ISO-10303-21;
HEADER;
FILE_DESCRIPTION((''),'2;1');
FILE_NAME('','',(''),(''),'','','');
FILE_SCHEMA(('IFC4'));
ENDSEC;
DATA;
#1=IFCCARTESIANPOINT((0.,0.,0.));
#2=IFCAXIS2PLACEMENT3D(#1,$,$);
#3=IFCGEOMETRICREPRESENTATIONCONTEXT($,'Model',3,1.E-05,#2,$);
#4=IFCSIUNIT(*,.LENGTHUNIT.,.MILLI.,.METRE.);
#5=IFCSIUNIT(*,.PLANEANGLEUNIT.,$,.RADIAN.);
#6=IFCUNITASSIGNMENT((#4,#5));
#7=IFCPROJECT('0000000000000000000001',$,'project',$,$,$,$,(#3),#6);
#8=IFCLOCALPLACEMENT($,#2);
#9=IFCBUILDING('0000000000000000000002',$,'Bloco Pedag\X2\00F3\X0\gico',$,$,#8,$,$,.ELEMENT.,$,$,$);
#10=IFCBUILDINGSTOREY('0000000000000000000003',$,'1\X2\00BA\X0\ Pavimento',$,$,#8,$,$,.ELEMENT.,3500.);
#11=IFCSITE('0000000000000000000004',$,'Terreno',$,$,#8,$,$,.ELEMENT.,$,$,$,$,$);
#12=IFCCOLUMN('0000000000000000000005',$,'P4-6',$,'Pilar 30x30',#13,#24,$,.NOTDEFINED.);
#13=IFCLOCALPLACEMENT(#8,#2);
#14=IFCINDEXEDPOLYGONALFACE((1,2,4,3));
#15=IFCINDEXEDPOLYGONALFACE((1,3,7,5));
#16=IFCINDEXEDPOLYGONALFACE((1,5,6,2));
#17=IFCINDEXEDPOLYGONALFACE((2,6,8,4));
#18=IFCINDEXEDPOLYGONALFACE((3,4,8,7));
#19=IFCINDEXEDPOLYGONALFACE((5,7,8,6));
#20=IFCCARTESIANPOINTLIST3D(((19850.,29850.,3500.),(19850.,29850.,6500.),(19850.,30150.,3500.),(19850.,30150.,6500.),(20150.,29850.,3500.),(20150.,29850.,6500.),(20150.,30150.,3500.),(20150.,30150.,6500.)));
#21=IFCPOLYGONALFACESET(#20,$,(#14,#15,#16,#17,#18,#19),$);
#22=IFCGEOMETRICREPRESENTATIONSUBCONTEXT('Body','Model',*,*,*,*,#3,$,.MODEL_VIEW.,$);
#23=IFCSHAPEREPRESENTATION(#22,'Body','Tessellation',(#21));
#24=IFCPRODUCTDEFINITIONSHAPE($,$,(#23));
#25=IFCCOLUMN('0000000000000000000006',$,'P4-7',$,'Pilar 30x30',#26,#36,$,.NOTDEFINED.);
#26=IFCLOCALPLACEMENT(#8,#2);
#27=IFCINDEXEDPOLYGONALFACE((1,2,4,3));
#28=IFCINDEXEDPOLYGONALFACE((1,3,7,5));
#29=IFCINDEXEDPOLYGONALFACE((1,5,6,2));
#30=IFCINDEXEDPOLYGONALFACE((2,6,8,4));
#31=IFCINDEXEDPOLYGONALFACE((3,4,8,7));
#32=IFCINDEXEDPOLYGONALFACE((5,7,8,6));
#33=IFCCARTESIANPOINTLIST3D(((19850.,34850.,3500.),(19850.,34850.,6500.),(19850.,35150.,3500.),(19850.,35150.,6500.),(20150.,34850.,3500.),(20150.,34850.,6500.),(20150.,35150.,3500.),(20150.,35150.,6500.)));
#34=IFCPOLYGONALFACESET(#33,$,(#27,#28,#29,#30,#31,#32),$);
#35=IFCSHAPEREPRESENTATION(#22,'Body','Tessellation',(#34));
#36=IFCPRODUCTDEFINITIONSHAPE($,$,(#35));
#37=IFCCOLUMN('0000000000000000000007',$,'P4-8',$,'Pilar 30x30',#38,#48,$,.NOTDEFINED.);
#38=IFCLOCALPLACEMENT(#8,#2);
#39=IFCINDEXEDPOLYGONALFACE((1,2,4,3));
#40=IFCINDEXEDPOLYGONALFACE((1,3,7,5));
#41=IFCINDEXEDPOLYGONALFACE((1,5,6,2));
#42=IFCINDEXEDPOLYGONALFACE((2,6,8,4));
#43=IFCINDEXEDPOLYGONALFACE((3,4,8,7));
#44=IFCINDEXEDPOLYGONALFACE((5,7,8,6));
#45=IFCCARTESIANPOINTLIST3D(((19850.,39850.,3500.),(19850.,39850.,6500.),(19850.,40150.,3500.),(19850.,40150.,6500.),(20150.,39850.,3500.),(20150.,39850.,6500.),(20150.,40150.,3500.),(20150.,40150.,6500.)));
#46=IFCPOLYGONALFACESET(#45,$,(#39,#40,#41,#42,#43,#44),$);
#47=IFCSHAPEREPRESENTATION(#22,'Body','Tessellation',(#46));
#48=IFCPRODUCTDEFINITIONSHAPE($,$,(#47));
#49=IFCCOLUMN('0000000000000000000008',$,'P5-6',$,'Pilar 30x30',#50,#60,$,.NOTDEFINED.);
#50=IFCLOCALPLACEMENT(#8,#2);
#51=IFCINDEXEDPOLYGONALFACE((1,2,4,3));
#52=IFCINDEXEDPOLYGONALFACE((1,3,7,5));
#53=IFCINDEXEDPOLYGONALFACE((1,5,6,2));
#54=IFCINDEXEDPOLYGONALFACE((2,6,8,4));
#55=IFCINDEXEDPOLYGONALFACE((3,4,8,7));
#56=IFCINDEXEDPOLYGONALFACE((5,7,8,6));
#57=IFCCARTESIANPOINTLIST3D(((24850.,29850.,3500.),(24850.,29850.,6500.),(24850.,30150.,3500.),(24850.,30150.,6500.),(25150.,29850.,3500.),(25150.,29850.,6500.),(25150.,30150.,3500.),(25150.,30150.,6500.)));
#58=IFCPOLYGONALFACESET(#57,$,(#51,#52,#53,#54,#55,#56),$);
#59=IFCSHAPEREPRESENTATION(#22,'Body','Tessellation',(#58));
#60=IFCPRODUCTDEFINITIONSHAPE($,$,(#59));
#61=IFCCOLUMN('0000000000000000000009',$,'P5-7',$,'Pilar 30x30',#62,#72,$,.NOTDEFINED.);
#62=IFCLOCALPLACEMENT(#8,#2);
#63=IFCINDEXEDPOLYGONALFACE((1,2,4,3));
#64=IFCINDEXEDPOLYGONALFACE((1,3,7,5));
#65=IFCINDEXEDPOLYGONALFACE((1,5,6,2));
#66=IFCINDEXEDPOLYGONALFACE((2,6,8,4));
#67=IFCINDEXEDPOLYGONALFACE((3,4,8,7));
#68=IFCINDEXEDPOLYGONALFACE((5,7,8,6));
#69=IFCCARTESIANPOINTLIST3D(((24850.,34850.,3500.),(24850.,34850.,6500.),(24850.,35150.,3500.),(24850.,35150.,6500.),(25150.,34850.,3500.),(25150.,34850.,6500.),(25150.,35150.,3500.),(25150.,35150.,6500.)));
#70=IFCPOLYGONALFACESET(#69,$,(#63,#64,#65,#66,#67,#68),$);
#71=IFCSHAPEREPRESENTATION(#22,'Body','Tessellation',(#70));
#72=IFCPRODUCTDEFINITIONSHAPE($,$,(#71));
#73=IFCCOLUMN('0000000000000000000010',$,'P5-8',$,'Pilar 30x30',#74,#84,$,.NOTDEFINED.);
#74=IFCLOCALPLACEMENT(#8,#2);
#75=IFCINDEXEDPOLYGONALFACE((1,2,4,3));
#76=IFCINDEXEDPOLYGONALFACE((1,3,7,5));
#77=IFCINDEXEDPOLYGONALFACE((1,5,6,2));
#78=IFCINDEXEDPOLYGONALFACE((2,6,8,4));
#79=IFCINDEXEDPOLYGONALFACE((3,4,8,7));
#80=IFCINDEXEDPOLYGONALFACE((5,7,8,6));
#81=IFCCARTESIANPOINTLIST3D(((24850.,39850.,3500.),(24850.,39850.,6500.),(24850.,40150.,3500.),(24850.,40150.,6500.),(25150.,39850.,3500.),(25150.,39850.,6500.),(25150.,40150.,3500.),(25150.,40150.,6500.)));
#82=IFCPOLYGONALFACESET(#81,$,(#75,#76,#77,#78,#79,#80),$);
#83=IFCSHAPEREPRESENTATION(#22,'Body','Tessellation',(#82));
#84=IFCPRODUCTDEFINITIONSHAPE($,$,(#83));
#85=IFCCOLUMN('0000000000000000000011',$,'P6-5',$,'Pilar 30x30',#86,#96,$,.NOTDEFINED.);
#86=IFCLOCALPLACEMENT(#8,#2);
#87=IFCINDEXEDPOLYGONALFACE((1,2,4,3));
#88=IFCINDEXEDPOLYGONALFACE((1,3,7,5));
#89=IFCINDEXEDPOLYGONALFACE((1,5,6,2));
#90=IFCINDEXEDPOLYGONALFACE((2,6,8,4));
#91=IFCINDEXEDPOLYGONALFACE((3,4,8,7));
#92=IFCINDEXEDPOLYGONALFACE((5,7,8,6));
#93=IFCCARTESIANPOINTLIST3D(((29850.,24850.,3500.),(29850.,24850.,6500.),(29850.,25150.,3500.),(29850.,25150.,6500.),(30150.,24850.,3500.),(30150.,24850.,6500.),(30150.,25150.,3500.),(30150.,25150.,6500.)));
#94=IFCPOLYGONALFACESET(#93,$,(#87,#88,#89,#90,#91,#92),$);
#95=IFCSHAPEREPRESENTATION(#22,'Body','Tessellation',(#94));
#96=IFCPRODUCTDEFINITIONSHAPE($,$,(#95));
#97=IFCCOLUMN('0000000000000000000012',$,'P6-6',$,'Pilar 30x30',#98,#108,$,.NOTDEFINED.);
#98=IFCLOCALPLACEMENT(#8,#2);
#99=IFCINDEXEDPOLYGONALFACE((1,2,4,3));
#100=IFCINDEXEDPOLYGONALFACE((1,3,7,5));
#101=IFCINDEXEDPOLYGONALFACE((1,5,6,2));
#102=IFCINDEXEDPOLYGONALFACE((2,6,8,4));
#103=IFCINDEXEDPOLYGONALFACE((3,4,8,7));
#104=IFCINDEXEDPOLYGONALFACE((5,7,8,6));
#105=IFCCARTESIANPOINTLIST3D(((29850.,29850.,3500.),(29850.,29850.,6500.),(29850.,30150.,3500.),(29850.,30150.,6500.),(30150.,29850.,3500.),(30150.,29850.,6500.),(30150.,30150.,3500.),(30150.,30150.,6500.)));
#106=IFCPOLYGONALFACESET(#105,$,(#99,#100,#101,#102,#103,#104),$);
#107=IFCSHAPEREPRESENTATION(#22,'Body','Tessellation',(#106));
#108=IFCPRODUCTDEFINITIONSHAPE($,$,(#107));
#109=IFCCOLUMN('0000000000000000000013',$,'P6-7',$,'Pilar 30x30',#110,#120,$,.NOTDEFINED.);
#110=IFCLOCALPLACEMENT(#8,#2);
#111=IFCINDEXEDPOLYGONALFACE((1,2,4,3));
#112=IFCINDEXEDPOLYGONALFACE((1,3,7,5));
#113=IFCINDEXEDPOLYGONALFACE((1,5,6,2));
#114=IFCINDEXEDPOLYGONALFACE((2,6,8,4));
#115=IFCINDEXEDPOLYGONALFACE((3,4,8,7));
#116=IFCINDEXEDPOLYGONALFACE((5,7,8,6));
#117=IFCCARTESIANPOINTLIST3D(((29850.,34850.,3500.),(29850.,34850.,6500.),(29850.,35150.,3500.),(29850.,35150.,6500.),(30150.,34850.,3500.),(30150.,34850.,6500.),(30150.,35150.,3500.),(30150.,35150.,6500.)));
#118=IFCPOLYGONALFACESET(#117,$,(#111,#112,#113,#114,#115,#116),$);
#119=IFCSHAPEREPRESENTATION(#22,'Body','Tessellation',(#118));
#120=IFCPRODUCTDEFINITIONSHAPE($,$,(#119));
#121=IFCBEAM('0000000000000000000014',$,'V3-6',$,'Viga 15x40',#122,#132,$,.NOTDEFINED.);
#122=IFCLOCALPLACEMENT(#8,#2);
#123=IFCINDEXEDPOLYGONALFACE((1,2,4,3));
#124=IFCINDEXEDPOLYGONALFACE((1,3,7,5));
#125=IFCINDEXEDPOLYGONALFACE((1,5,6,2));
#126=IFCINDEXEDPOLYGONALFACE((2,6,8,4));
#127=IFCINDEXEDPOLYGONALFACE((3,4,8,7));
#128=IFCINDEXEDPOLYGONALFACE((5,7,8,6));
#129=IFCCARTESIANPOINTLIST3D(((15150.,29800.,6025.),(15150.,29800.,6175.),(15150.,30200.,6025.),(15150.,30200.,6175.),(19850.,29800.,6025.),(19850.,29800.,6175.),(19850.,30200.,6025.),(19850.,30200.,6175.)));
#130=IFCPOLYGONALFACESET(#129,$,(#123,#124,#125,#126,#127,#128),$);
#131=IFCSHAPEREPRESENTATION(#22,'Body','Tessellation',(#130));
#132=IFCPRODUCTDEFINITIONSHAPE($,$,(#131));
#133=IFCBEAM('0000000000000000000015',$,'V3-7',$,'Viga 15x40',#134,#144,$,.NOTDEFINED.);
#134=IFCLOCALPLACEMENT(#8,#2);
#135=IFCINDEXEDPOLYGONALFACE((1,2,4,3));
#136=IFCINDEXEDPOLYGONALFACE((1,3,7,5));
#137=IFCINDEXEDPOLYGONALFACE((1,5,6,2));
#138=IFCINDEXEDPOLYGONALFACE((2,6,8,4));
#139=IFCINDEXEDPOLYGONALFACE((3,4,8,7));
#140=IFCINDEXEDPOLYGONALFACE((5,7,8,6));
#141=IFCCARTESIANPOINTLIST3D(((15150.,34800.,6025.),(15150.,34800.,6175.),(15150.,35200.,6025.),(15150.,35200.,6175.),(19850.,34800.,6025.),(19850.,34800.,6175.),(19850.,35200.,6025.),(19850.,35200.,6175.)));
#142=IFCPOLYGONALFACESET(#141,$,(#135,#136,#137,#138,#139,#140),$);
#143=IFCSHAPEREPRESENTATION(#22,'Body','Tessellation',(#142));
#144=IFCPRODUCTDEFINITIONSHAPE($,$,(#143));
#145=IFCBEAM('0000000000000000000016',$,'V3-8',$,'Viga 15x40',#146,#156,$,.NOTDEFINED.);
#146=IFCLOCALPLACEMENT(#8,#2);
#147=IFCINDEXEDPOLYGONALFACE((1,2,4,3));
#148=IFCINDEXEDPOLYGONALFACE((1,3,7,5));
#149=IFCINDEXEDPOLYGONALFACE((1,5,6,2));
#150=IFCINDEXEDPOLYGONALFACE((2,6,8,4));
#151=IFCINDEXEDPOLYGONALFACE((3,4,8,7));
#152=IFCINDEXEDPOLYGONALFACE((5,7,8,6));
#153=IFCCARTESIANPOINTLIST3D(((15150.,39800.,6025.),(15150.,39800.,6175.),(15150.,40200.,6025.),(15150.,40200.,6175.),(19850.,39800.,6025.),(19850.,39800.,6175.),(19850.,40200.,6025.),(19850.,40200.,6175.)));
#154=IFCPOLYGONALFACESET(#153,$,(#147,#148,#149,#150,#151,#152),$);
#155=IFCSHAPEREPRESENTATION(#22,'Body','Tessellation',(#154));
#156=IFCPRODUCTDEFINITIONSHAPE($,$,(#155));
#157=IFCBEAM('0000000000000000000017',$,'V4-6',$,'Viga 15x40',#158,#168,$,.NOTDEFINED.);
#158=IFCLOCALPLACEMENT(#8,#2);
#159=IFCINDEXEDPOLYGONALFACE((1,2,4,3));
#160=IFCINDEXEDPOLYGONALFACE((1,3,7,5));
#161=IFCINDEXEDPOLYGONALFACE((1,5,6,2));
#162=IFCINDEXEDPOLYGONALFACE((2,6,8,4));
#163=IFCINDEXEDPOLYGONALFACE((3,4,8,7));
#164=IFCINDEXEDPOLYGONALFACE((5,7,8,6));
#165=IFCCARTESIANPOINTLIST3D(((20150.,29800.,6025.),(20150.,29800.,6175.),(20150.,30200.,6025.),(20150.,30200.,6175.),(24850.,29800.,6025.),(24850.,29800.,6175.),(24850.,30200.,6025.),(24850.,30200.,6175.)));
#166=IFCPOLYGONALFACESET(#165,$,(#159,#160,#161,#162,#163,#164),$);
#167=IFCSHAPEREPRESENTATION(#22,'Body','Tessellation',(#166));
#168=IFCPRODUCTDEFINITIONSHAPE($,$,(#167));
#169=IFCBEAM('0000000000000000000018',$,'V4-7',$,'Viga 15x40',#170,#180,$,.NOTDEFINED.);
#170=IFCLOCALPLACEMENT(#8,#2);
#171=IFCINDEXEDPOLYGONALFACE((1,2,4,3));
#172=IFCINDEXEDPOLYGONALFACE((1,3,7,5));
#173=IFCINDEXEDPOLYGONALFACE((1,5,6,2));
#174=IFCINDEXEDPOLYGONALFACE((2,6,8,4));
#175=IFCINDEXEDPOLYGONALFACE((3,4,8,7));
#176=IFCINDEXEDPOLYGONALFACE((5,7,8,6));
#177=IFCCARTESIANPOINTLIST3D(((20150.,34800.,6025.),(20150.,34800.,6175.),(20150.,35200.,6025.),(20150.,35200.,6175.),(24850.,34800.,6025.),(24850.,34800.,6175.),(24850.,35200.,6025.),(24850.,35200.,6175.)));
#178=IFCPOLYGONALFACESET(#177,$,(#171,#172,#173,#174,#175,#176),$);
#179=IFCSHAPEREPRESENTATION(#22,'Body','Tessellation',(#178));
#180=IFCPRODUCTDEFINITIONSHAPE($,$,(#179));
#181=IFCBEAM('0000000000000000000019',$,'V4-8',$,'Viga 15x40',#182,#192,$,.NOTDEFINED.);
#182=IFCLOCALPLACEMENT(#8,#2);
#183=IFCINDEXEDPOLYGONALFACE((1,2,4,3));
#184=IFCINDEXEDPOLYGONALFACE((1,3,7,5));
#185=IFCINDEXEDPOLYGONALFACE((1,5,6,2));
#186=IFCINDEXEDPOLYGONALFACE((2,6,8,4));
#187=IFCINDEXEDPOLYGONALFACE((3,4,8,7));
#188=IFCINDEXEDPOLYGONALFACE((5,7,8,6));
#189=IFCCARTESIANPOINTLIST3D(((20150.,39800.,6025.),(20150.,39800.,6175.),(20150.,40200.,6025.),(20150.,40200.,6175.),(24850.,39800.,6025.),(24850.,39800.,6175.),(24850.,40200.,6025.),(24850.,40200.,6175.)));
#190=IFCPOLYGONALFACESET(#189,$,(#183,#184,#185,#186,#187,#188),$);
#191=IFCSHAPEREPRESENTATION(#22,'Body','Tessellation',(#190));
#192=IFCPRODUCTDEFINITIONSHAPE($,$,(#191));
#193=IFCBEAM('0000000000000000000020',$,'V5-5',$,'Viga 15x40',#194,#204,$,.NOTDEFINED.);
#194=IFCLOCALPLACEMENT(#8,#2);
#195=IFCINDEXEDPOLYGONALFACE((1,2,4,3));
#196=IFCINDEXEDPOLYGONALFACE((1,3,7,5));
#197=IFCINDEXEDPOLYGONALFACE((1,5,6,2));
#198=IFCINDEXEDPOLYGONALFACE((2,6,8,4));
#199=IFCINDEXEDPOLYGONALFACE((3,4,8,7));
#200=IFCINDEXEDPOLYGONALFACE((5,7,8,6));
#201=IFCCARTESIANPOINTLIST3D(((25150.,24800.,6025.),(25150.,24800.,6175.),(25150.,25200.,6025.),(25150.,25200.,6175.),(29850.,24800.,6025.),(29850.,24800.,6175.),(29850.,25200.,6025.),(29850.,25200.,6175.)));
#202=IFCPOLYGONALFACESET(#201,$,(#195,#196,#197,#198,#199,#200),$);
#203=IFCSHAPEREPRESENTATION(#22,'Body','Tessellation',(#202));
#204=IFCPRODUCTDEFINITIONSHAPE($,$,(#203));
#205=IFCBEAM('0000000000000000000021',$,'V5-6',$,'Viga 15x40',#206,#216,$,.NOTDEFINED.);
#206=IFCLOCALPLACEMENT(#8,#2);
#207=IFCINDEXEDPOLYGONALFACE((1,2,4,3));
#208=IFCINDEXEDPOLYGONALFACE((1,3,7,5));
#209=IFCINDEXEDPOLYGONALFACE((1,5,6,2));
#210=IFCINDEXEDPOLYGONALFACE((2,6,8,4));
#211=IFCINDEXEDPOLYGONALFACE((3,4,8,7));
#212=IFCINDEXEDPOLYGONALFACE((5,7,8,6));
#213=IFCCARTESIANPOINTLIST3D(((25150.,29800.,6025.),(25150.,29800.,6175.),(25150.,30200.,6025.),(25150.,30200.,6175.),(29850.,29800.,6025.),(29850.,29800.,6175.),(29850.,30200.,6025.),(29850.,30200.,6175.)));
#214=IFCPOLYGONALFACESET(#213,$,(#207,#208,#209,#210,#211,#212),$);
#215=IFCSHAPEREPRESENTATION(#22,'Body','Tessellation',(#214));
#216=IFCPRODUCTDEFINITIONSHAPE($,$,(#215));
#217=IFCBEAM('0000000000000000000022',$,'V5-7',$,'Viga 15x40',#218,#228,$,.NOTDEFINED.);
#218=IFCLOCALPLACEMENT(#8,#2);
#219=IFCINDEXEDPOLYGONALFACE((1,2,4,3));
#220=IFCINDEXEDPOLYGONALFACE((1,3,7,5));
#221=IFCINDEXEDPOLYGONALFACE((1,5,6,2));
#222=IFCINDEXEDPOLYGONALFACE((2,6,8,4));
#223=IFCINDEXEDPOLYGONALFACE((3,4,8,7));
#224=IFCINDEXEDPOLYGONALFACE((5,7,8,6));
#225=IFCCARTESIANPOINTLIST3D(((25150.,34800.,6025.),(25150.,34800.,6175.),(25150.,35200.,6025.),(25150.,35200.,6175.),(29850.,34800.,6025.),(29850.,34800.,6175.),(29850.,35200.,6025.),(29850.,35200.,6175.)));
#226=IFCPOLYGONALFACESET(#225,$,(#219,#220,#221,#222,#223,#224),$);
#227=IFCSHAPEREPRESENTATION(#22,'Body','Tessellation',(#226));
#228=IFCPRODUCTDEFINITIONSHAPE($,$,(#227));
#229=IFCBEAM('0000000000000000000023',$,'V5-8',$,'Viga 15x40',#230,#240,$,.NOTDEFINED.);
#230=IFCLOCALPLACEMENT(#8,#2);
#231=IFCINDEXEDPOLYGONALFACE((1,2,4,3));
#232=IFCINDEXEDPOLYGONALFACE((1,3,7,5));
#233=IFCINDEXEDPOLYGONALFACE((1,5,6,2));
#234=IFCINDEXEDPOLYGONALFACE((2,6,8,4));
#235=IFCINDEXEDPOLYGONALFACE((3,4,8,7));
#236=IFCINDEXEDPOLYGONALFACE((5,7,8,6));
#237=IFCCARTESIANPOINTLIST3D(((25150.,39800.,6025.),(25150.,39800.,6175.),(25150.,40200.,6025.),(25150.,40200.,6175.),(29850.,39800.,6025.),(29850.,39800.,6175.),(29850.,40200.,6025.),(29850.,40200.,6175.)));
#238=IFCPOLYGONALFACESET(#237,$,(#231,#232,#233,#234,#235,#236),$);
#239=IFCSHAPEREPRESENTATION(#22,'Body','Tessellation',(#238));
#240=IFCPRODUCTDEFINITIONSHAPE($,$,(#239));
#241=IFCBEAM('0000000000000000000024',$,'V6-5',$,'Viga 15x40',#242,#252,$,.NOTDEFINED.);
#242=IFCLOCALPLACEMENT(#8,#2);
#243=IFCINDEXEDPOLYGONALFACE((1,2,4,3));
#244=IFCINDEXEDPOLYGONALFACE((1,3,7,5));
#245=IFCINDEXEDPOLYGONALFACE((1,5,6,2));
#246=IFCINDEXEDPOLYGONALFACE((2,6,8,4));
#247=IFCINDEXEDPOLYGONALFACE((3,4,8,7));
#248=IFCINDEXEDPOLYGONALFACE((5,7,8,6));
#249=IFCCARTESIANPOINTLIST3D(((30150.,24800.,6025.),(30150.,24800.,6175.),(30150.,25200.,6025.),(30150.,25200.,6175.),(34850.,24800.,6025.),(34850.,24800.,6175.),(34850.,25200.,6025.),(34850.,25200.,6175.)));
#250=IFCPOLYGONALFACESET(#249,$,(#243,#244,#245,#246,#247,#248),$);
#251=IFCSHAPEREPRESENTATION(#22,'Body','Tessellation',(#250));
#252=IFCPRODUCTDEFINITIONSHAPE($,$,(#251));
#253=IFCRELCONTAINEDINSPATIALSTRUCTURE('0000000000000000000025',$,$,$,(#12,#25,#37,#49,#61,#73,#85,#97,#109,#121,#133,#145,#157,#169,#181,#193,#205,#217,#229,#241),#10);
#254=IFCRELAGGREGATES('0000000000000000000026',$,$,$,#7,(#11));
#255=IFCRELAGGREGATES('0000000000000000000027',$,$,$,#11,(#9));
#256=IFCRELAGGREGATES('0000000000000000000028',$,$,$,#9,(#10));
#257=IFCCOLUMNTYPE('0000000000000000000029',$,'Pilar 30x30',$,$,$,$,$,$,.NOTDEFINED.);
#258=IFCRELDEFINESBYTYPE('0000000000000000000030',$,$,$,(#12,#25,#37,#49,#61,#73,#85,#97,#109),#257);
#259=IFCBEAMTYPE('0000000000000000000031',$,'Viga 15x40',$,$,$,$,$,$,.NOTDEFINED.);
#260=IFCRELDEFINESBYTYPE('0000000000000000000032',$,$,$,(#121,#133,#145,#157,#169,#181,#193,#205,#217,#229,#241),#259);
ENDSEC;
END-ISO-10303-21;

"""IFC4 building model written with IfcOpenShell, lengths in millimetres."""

from ifc_helpers import new_model, si_unit, frame, origin, origin_2d, place, context, subcontext, project, spatial, rectangle, extrude, type_object, element, save


model = new_model("IFC4")

# Units and contexts
model_context = context("Model", 3, precision=1e-05, world=origin())
body_context = subcontext(model_context, "Body", "Model", "MODEL_VIEW")
ifc_project = project(units=[si_unit("LENGTHUNIT", "METRE", prefix="MILLI"), si_unit("PLANEANGLEUNIT", "RADIAN")], contexts=[model_context])

# Site, building, storey
placement = place(None, origin())
site = spatial("IfcSite", under=ifc_project, at=placement, Name="Terreno", CompositionType="ELEMENT")
building = spatial("IfcBuilding", under=site, at=placement, Name="Bloco Pedagógico", CompositionType="ELEMENT")
storey = spatial("IfcBuildingStorey", under=building, at=placement, Name="1º Pavimento", CompositionType="ELEMENT", Elevation=3500.0)

# Columns
column_type = type_object("IfcColumnType", Name="Pilar 30x30", PredefinedType="NOTDEFINED")
for number, where, z_axis, x_axis, name in (
    (1, (20000.0, 30000.0, 3500.0), (0.0, 0.0, 1.0), (1.0, 0.0, 0.0), "P4-6"),
    (2, (20000.0, 35000.0, 3500.0), (0.0, 0.0, 1.0), (1.0, 0.0, 0.0), "P4-7"),
    (3, (20000.0, 40000.0, 3500.0), (0.0, 0.0, 1.0), (1.0, 0.0, 0.0), "P4-8"),
    (4, (25000.0, 30000.0, 3500.0), (0.0, 0.0, 1.0), (1.0, 0.0, 0.0), "P5-6"),
    (5, (25000.0, 35000.0, 3500.0), (0.0, 0.0, 1.0), (1.0, 0.0, 0.0), "P5-7"),
    (6, (25000.0, 40000.0, 3500.0), (0.0, 0.0, 1.0), (1.0, 0.0, 0.0), "P5-8"),
    (7, (30000.0, 25000.0, 3500.0), (0.0, 0.0, 1.0), (1.0, 0.0, 0.0), "P6-5"),
    (8, (30000.0, 30000.0, 3500.0), (0.0, 0.0, 1.0), (1.0, 0.0, 0.0), "P6-6"),
    (9, (30000.0, 35000.0, 3500.0), (0.0, 0.0, 1.0), (1.0, 0.0, 0.0), "P6-7"),
):
    element("IfcColumn", number, at=place(None, frame(where, z_axis=z_axis, x_axis=x_axis)), inside=storey, type_object=column_type, Name=name, ObjectType="Pilar 30x30", PredefinedType="NOTDEFINED", context=body_context, shape_type="SweptSolid", body=[
        extrude(rectangle(XDim=300.0, YDim=300.0, at=origin_2d()), None, (0.0, 0.0, 1.0), 3000.0),
    ])

# Beams
beam_type = type_object("IfcBeamType", Name="Viga 15x40", PredefinedType="NOTDEFINED")
for number, where, z_axis, x_axis, name in (
    (10, (15150.0, 30000.0, 6100.0), (1.0, 0.0, 0.0), (0.0, 1.0, 0.0), "V3-6"),
    (11, (15150.0, 35000.0, 6100.0), (1.0, 0.0, 0.0), (0.0, 1.0, 0.0), "V3-7"),
    (12, (15150.0, 40000.0, 6100.0), (1.0, 0.0, 0.0), (0.0, 1.0, 0.0), "V3-8"),
    (13, (20150.0, 30000.0, 6100.0), (1.0, 0.0, 0.0), (0.0, 1.0, 0.0), "V4-6"),
    (14, (20150.0, 35000.0, 6100.0), (1.0, 0.0, 0.0), (0.0, 1.0, 0.0), "V4-7"),
    (15, (20150.0, 40000.0, 6100.0), (1.0, 0.0, 0.0), (0.0, 1.0, 0.0), "V4-8"),
    (16, (25150.0, 25000.0, 6100.0), (1.0, 0.0, 0.0), (0.0, 1.0, 0.0), "V5-5"),
    (17, (25150.0, 30000.0, 6100.0), (1.0, 0.0, 0.0), (0.0, 1.0, 0.0), "V5-6"),
    (18, (25150.0, 35000.0, 6100.0), (1.0, 0.0, 0.0), (0.0, 1.0, 0.0), "V5-7"),
    (19, (25150.0, 40000.0, 6100.0), (1.0, 0.0, 0.0), (0.0, 1.0, 0.0), "V5-8"),
    (20, (30150.0, 25000.0, 6100.0), (1.0, 0.0, 0.0), (0.0, 1.0, 0.0), "V6-5"),
):
    element("IfcBeam", number, at=place(None, frame(where, z_axis=z_axis, x_axis=x_axis)), inside=storey, type_object=beam_type, Name=name, ObjectType="Viga 15x40", PredefinedType="NOTDEFINED", context=body_context, shape_type="SweptSolid", body=[
        extrude(rectangle(XDim=400.0, YDim=150.0, at=origin_2d()), None, (0.0, 0.0, 1.0), 4700.0),
    ])

save(model, "model.ifc")
